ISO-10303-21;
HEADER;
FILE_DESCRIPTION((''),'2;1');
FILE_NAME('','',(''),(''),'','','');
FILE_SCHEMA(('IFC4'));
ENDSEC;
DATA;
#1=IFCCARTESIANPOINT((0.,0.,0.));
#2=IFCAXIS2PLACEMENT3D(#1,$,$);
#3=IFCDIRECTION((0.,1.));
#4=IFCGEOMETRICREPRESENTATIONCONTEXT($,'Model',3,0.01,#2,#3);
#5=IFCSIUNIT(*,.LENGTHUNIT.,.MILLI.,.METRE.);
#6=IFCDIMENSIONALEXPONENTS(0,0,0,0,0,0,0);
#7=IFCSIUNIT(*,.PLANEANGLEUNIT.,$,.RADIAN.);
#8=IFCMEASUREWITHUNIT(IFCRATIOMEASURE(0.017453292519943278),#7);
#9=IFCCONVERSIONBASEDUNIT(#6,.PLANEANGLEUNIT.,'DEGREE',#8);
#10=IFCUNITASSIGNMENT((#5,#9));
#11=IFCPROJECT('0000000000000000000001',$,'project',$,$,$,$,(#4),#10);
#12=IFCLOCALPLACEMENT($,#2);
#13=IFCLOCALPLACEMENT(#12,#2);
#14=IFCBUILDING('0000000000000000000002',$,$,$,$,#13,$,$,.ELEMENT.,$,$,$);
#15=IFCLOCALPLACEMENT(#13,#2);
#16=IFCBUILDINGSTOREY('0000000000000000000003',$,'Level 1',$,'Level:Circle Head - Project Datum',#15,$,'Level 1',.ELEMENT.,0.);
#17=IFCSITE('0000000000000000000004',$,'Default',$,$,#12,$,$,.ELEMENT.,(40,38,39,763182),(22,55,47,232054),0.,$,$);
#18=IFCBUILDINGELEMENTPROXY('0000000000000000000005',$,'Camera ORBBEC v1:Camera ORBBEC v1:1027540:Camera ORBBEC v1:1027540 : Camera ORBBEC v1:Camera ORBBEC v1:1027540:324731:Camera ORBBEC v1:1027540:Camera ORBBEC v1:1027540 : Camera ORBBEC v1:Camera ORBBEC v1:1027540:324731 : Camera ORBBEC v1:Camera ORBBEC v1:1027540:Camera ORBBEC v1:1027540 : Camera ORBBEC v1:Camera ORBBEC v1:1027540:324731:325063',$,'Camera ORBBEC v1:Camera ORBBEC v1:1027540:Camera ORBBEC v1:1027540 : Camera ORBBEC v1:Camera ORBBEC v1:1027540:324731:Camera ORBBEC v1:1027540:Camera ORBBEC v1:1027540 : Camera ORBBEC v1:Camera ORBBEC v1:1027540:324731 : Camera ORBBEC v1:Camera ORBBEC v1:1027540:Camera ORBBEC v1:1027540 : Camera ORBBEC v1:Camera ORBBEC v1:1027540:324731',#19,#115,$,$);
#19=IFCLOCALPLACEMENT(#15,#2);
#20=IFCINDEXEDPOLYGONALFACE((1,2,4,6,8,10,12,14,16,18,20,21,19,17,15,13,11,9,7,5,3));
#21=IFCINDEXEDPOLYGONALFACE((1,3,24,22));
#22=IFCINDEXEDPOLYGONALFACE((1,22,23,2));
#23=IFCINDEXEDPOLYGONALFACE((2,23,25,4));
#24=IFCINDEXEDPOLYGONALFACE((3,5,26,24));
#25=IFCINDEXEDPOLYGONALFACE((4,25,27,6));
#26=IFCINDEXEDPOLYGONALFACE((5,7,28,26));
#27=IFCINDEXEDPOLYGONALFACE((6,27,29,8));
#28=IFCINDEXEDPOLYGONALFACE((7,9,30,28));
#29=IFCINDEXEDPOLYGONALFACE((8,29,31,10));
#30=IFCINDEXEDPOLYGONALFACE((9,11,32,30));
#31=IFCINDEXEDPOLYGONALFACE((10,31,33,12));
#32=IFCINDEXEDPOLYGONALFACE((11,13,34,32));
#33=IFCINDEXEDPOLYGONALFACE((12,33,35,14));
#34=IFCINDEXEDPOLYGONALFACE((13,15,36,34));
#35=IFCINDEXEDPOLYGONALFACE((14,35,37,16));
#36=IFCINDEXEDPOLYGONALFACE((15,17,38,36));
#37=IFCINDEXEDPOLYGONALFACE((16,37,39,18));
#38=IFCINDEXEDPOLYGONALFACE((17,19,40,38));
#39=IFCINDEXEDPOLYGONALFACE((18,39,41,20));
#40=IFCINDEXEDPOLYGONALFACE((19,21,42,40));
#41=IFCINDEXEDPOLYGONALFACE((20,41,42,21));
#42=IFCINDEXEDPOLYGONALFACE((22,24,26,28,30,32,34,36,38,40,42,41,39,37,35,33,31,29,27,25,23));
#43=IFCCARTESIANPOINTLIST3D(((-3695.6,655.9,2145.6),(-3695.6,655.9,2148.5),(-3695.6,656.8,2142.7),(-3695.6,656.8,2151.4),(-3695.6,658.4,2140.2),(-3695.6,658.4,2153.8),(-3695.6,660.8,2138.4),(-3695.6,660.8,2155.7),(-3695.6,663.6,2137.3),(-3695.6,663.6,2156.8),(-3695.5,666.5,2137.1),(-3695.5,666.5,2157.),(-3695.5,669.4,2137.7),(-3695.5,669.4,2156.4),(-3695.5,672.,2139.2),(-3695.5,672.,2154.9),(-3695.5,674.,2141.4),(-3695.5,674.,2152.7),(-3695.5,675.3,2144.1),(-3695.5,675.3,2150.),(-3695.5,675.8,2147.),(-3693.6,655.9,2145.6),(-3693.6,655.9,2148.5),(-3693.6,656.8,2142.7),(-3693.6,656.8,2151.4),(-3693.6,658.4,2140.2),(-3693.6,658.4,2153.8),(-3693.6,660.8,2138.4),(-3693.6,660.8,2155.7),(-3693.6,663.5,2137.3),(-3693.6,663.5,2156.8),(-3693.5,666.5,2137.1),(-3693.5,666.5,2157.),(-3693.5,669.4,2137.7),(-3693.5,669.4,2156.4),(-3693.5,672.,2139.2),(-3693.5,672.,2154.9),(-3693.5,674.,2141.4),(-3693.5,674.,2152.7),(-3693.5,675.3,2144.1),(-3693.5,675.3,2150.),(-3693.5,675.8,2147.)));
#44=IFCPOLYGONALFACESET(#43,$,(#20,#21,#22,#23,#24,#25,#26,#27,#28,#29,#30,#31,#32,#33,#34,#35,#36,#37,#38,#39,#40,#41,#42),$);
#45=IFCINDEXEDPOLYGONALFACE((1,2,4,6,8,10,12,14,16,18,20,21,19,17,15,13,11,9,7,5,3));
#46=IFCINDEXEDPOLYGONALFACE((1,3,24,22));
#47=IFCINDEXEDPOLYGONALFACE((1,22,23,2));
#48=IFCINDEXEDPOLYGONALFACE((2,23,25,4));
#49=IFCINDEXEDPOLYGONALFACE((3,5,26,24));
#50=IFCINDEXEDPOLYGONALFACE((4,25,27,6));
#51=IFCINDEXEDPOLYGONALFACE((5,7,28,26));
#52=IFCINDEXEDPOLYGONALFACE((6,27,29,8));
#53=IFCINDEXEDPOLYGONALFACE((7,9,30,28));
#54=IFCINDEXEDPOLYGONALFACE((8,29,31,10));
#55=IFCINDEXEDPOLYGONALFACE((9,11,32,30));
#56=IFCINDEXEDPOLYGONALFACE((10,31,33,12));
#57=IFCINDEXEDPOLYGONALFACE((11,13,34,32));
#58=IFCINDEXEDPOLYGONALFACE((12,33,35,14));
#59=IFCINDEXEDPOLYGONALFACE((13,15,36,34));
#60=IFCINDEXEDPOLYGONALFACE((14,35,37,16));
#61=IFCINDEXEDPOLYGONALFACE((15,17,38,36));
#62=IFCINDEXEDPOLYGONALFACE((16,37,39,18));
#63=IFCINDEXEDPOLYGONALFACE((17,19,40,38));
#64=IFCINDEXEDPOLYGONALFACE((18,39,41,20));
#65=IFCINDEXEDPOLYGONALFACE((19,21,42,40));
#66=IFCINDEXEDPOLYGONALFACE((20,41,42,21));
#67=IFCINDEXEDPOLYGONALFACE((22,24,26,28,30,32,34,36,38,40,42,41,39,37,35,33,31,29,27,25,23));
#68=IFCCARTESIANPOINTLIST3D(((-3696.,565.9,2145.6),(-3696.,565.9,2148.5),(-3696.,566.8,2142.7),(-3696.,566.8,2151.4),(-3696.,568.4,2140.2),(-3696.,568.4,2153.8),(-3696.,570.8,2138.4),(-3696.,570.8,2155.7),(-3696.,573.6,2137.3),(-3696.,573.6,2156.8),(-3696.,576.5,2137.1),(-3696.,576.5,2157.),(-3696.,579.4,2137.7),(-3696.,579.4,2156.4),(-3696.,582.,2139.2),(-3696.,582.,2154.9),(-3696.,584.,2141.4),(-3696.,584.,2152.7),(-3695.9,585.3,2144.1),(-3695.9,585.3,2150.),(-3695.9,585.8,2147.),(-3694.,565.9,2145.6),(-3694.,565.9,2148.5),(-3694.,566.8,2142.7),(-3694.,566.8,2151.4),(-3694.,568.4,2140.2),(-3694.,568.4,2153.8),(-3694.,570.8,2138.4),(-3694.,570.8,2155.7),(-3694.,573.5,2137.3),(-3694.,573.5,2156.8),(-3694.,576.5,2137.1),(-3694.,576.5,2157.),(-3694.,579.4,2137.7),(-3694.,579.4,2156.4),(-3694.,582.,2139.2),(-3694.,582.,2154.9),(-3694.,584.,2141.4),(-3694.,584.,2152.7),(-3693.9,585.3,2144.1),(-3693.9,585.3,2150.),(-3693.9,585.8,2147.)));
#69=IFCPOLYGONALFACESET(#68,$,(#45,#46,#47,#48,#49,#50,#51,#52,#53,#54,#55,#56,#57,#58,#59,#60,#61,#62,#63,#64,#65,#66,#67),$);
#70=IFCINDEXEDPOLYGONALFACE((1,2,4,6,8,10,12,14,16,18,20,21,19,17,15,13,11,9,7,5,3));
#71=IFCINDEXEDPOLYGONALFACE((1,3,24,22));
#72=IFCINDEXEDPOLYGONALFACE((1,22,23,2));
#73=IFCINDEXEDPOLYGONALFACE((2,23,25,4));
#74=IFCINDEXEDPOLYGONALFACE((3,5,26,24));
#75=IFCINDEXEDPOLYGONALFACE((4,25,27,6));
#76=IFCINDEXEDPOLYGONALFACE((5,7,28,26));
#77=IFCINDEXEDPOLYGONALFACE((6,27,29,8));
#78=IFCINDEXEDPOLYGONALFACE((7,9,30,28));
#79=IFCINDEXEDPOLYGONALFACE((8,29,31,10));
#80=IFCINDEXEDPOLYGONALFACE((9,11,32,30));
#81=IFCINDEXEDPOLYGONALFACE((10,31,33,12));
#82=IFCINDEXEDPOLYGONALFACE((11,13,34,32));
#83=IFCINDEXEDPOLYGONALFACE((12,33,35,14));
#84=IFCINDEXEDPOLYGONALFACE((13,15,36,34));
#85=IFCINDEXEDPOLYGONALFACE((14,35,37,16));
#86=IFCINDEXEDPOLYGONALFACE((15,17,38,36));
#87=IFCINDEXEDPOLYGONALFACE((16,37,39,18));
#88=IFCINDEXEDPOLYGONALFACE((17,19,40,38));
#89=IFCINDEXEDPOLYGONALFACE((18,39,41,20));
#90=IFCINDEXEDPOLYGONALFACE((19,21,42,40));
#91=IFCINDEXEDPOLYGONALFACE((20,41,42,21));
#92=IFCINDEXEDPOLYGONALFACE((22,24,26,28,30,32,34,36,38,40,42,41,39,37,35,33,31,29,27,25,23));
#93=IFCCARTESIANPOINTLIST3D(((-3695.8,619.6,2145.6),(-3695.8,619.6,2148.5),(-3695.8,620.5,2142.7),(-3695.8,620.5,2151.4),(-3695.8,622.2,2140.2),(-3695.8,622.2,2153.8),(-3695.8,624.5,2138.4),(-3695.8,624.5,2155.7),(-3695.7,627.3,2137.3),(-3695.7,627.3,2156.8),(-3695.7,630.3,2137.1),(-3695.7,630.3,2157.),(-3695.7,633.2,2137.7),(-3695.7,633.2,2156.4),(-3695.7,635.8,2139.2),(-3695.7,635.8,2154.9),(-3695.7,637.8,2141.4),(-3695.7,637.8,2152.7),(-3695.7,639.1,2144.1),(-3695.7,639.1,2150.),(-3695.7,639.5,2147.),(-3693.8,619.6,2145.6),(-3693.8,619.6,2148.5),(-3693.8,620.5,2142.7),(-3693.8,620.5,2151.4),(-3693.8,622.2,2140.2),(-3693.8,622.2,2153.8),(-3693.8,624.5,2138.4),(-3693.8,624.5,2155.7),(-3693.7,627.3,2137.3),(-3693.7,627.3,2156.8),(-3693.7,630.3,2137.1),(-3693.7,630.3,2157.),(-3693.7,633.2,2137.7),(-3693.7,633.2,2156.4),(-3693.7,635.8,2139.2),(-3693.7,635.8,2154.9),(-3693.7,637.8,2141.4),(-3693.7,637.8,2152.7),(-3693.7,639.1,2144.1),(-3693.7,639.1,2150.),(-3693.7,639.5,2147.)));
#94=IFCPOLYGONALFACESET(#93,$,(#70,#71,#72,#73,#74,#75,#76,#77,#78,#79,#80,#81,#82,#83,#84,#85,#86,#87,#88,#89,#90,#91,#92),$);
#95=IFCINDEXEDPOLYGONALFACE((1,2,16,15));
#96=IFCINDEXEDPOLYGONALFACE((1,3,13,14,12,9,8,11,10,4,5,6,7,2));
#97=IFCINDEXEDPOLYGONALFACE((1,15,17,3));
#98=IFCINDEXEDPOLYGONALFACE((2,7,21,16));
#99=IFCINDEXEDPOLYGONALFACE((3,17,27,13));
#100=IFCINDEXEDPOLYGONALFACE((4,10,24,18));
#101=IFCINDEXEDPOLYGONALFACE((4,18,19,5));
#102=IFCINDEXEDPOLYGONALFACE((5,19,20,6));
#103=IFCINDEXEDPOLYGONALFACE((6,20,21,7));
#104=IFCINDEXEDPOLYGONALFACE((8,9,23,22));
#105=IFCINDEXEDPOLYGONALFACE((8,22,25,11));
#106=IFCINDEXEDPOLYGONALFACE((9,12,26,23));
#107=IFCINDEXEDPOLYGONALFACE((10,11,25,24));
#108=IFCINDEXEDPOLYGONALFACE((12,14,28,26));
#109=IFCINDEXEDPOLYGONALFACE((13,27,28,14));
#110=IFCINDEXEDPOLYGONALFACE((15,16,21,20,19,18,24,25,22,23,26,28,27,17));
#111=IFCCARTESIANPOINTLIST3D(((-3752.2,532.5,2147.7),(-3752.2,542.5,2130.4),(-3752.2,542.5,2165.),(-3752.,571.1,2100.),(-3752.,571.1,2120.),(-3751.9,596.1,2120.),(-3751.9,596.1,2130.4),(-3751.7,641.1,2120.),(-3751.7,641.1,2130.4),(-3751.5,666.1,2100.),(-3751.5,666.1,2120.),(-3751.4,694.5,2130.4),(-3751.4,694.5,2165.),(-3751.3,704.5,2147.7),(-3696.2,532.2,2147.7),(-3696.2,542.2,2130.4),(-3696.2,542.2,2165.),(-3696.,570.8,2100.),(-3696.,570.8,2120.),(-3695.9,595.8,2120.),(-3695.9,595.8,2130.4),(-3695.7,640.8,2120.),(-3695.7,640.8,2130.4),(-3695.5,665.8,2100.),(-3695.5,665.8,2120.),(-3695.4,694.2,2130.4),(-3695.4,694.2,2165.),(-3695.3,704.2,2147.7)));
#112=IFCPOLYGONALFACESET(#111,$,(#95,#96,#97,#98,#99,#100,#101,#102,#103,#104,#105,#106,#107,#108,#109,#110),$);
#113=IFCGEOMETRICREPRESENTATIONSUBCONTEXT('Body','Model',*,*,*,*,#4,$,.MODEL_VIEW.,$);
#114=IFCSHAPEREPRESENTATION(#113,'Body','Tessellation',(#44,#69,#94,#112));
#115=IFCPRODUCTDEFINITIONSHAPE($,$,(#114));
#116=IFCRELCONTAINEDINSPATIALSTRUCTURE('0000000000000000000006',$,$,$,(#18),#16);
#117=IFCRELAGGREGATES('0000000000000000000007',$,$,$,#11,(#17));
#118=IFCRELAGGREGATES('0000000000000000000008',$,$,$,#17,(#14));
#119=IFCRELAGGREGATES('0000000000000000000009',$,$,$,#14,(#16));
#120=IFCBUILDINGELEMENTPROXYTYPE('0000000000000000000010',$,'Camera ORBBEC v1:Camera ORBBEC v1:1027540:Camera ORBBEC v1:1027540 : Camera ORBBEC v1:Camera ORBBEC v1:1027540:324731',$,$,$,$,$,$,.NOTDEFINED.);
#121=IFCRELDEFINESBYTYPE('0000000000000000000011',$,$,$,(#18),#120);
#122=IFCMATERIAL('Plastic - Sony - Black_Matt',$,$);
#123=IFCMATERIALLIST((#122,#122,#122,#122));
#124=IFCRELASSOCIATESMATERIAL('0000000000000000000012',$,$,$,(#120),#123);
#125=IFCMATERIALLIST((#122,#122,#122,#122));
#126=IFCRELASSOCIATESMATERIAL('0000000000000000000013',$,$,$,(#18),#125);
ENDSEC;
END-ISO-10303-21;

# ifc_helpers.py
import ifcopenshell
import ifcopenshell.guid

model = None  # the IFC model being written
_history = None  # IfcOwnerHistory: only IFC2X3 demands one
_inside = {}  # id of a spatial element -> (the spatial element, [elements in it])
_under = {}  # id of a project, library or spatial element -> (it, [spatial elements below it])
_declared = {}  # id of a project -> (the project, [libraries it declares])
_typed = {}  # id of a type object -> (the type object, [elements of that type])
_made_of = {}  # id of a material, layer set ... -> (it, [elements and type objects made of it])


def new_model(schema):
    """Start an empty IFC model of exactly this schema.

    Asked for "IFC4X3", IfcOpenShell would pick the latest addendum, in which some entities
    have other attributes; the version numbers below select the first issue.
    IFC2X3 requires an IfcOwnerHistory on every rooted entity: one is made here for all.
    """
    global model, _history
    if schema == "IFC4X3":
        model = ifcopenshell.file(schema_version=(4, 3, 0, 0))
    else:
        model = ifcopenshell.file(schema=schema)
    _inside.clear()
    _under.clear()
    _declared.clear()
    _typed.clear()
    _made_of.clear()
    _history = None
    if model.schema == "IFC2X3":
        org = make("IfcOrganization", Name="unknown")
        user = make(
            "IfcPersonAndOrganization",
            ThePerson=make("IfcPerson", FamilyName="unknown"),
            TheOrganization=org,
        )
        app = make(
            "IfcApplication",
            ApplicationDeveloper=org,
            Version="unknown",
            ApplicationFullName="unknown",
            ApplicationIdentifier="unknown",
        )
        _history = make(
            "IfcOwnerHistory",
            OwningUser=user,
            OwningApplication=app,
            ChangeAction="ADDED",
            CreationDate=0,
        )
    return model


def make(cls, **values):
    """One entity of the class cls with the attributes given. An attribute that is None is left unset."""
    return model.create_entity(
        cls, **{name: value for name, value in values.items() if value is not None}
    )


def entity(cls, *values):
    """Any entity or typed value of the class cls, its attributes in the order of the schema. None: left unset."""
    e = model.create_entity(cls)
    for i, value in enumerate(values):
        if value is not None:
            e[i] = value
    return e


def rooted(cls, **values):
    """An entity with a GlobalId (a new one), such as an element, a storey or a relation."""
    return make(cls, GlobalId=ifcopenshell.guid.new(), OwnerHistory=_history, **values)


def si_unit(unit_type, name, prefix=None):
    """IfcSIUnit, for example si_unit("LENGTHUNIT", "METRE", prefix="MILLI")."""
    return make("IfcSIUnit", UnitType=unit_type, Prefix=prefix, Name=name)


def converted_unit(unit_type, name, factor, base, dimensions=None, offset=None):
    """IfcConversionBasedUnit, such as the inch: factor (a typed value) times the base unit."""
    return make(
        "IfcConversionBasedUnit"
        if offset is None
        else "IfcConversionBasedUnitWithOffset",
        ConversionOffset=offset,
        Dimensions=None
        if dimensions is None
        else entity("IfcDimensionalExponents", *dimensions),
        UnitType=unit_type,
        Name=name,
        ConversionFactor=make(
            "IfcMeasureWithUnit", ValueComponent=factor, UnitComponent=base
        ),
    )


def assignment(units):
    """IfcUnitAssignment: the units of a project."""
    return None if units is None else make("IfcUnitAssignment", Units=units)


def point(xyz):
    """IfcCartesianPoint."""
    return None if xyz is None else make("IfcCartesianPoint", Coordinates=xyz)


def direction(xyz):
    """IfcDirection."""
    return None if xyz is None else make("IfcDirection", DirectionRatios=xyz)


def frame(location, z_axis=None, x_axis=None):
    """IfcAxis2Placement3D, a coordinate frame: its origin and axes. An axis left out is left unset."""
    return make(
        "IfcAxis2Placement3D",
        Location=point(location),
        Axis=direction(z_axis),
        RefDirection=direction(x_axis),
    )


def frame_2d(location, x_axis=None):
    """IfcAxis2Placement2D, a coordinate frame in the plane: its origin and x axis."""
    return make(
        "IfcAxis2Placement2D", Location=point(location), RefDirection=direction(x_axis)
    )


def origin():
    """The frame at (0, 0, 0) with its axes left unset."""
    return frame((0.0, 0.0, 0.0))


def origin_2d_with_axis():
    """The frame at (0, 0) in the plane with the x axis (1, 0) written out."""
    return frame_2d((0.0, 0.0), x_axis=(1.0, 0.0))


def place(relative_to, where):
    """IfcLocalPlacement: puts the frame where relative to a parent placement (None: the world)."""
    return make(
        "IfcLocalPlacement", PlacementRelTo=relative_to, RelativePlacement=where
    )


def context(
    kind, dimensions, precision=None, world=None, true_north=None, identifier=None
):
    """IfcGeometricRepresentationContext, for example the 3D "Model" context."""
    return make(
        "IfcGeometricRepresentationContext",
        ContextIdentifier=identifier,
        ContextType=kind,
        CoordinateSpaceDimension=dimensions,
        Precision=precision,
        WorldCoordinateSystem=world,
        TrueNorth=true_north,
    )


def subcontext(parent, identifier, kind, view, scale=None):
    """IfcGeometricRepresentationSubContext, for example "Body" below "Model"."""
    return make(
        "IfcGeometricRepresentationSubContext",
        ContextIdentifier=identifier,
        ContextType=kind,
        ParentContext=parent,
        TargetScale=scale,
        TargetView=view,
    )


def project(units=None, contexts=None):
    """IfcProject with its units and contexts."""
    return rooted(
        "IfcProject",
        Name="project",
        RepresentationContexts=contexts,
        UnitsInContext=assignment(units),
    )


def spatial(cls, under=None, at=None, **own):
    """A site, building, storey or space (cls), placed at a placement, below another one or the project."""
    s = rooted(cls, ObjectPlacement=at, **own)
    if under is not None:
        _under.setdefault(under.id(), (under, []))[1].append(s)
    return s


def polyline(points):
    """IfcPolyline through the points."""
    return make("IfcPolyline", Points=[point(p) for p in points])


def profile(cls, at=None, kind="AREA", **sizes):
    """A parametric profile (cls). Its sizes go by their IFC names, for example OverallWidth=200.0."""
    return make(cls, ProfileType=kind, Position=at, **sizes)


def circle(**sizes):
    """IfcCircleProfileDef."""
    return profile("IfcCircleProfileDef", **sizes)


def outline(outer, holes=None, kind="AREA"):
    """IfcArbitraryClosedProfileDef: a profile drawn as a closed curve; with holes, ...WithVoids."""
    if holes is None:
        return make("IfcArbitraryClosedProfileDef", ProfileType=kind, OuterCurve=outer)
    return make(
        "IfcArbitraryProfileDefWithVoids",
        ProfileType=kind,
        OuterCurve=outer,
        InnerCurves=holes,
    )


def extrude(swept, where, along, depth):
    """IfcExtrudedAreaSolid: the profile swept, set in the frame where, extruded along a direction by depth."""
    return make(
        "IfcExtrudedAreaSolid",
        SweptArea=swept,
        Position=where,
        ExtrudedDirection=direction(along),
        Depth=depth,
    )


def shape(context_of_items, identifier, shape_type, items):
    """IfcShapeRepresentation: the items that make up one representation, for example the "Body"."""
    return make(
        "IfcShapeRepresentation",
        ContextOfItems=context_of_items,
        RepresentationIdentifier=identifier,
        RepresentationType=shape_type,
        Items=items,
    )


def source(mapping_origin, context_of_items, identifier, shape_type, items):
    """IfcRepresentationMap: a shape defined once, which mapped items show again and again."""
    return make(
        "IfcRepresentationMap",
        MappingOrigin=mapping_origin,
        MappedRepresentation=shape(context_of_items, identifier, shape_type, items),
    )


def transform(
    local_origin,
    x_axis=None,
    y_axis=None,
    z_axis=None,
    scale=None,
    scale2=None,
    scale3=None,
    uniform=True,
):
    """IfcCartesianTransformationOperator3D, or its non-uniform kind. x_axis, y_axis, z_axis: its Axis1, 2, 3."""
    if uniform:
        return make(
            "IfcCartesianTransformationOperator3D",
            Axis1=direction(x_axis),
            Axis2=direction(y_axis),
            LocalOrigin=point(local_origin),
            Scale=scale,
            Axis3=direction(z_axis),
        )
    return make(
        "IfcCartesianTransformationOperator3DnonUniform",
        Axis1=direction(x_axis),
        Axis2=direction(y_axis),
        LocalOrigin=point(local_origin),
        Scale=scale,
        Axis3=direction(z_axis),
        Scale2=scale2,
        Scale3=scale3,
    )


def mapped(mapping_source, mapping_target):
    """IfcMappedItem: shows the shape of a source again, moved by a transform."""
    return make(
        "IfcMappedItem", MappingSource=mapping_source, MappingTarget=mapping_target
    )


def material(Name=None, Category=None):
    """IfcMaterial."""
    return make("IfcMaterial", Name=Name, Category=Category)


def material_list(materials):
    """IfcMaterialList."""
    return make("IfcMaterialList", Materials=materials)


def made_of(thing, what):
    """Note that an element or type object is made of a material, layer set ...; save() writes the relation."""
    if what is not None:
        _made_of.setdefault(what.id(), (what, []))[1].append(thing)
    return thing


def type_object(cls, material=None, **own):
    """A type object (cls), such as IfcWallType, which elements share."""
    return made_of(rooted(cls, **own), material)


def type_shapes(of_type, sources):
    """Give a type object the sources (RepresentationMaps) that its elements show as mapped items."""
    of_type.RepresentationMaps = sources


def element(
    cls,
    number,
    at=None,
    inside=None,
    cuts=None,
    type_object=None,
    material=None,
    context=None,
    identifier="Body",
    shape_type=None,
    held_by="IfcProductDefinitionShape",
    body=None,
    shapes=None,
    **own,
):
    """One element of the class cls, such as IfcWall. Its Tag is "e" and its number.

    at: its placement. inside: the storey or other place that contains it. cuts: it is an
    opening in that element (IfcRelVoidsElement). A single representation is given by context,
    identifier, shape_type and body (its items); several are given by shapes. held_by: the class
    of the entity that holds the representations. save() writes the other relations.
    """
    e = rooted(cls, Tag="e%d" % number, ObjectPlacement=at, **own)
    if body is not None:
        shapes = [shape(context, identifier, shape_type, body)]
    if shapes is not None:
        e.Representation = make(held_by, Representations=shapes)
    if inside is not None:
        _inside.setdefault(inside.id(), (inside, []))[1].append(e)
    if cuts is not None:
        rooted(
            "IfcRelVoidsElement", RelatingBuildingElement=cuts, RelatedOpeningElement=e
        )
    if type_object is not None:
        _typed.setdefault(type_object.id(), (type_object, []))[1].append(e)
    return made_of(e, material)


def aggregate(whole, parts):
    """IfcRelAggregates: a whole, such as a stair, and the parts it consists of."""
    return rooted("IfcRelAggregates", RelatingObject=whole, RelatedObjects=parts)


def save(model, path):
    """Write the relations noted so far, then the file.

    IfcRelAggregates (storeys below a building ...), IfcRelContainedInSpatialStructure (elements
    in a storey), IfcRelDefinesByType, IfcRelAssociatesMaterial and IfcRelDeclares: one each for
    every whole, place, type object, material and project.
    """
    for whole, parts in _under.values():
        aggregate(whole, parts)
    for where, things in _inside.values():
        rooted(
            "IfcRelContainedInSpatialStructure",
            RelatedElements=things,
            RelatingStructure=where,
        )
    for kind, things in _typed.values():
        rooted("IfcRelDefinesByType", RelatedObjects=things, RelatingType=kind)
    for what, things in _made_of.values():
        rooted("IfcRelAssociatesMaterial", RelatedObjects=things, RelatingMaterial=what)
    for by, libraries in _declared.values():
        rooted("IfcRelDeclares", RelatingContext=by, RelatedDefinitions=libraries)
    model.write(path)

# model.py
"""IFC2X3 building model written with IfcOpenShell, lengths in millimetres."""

from ifc_helpers import new_model, entity, si_unit, converted_unit, direction, frame, frame_2d, origin, origin_2d_with_axis, place, context, subcontext, project, spatial, polyline, circle, outline, extrude, source, transform, mapped, material, material_list, type_object, type_shapes, element, save


model = new_model("IFC2X3")

# Units and contexts
model_context = context("Model", 3, precision=0.01, world=origin(), true_north=direction((0.0, 1.0)))
body_context = subcontext(model_context, "Body", "Model", "MODEL_VIEW")
ifc_project = project(units=[si_unit("LENGTHUNIT", "METRE", prefix="MILLI"), converted_unit("PLANEANGLEUNIT", "DEGREE", entity("IfcRatioMeasure", 0.017453292519943278), si_unit("PLANEANGLEUNIT", "RADIAN"), dimensions=[0, 0, 0, 0, 0, 0, 0])], contexts=[model_context])

# Site, building, storey
site_placement = place(None, origin())
site = spatial("IfcSite", under=ifc_project, at=site_placement, Name="Default", CompositionType="ELEMENT", RefLatitude=(40, 38, 39, 763182), RefLongitude=(22, 55, 47, 232054), RefElevation=0.0)
building_placement = place(site_placement, origin())
building = spatial("IfcBuilding", under=site, at=building_placement, CompositionType="ELEMENT")
storey_placement = place(building_placement, origin())
storey = spatial("IfcBuildingStorey", under=building, at=storey_placement, Name="Level 1", ObjectType="Level:Circle Head - Project Datum", LongName="Level 1", CompositionType="ELEMENT", Elevation=0.0)

# Building element proxy
ifc_material_1 = material(Name="Plastic - Sony - Black_Matt")
ifc_material_list_1 = material_list([ifc_material_1, ifc_material_1, ifc_material_1, ifc_material_1])
ifc_material_list_2 = material_list([ifc_material_1, ifc_material_1, ifc_material_1, ifc_material_1])
building_element_proxy_type_1 = type_object("IfcBuildingElementProxyType", Name="Camera ORBBEC v1:Camera ORBBEC v1:1027540:Camera ORBBEC v1:1027540 : Camera ORBBEC v1:Camera ORBBEC v1:1027540:324731", PredefinedType="NOTDEFINED", material=ifc_material_list_2)
shared_shape_1 = source(origin(), body_context, "Body", "SweptSolid", [
    extrude(circle(Radius=10.0, at=frame_2d((0.0, 0.0), x_axis=(1.0, 0.0))), frame((-3695.5, 665.8, 2147.0), z_axis=(0.999987, -0.005054, 0.0), x_axis=(0.005054, 0.999987, 0.0)), (0.0, 0.0, 1.0), 2.0),
    extrude(circle(Radius=10.0, at=origin_2d_with_axis()), frame((-3696.0, 575.8, 2147.0), z_axis=(0.999987, -0.005054, 0.0), x_axis=(0.005054, 0.999987, 0.0)), (0.0, 0.0, 1.0), 2.0),
    extrude(circle(Radius=10.0, at=frame_2d((0.0, 0.0), x_axis=(1.0, 0.0))), frame((-3695.7, 629.5, 2147.0), z_axis=(0.999987, -0.005054, 0.0), x_axis=(0.005054, 0.999987, 0.0)), (0.0, 0.0, 1.0), 2.0),
    extrude(outline(polyline([(-57.9, -65.9), (-37.9, -65.9), (-11.1, -19.5), (-2.2, -24.7), (-14.7, -46.3), (2.7, -56.3), (50.2, 25.9), (32.8, 35.9), (20.3, 14.3), (11.4, 19.5), (38.1, 65.7), (28.1, 83.0), (8.1, 83.0), (-67.9, -48.6), (-57.9, -65.9)])), frame((-3751.8, 618.5, 2130.5), z_axis=(0.999987, -0.005054, 0.0), x_axis=(0.002527, 0.499989, -0.866028)), (0.0, 0.0, 1.0), 56.0),
])
type_shapes(building_element_proxy_type_1, [shared_shape_1])
proxy_1_placement = place(storey_placement, origin())
element("IfcBuildingElementProxy", 1, at=proxy_1_placement, inside=storey, type_object=building_element_proxy_type_1, material=ifc_material_list_1, Name="Camera ORBBEC v1:Camera ORBBEC v1:1027540:Camera ORBBEC v1:1027540 : Camera ORBBEC v1:Camera ORBBEC v1:1027540:324731:Camera ORBBEC v1:1027540:Camera ORBBEC v1:1027540 : Camera ORBBEC v1:Camera ORBBEC v1:1027540:324731 : Camera ORBBEC v1:Camera ORBBEC v1:1027540:Camera ORBBEC v1:1027540 : Camera ORBBEC v1:Camera ORBBEC v1:1027540:324731:325063", ObjectType="Camera ORBBEC v1:Camera ORBBEC v1:1027540:Camera ORBBEC v1:1027540 : Camera ORBBEC v1:Camera ORBBEC v1:1027540:324731:Camera ORBBEC v1:1027540:Camera ORBBEC v1:1027540 : Camera ORBBEC v1:Camera ORBBEC v1:1027540:324731 : Camera ORBBEC v1:Camera ORBBEC v1:1027540:Camera ORBBEC v1:1027540 : Camera ORBBEC v1:Camera ORBBEC v1:1027540:324731", context=body_context, shape_type="MappedRepresentation", body=[
    mapped(shared_shape_1, transform((0.0, 0.0, 0.0), scale=1.0)),
])

save(model, "model.ifc")
